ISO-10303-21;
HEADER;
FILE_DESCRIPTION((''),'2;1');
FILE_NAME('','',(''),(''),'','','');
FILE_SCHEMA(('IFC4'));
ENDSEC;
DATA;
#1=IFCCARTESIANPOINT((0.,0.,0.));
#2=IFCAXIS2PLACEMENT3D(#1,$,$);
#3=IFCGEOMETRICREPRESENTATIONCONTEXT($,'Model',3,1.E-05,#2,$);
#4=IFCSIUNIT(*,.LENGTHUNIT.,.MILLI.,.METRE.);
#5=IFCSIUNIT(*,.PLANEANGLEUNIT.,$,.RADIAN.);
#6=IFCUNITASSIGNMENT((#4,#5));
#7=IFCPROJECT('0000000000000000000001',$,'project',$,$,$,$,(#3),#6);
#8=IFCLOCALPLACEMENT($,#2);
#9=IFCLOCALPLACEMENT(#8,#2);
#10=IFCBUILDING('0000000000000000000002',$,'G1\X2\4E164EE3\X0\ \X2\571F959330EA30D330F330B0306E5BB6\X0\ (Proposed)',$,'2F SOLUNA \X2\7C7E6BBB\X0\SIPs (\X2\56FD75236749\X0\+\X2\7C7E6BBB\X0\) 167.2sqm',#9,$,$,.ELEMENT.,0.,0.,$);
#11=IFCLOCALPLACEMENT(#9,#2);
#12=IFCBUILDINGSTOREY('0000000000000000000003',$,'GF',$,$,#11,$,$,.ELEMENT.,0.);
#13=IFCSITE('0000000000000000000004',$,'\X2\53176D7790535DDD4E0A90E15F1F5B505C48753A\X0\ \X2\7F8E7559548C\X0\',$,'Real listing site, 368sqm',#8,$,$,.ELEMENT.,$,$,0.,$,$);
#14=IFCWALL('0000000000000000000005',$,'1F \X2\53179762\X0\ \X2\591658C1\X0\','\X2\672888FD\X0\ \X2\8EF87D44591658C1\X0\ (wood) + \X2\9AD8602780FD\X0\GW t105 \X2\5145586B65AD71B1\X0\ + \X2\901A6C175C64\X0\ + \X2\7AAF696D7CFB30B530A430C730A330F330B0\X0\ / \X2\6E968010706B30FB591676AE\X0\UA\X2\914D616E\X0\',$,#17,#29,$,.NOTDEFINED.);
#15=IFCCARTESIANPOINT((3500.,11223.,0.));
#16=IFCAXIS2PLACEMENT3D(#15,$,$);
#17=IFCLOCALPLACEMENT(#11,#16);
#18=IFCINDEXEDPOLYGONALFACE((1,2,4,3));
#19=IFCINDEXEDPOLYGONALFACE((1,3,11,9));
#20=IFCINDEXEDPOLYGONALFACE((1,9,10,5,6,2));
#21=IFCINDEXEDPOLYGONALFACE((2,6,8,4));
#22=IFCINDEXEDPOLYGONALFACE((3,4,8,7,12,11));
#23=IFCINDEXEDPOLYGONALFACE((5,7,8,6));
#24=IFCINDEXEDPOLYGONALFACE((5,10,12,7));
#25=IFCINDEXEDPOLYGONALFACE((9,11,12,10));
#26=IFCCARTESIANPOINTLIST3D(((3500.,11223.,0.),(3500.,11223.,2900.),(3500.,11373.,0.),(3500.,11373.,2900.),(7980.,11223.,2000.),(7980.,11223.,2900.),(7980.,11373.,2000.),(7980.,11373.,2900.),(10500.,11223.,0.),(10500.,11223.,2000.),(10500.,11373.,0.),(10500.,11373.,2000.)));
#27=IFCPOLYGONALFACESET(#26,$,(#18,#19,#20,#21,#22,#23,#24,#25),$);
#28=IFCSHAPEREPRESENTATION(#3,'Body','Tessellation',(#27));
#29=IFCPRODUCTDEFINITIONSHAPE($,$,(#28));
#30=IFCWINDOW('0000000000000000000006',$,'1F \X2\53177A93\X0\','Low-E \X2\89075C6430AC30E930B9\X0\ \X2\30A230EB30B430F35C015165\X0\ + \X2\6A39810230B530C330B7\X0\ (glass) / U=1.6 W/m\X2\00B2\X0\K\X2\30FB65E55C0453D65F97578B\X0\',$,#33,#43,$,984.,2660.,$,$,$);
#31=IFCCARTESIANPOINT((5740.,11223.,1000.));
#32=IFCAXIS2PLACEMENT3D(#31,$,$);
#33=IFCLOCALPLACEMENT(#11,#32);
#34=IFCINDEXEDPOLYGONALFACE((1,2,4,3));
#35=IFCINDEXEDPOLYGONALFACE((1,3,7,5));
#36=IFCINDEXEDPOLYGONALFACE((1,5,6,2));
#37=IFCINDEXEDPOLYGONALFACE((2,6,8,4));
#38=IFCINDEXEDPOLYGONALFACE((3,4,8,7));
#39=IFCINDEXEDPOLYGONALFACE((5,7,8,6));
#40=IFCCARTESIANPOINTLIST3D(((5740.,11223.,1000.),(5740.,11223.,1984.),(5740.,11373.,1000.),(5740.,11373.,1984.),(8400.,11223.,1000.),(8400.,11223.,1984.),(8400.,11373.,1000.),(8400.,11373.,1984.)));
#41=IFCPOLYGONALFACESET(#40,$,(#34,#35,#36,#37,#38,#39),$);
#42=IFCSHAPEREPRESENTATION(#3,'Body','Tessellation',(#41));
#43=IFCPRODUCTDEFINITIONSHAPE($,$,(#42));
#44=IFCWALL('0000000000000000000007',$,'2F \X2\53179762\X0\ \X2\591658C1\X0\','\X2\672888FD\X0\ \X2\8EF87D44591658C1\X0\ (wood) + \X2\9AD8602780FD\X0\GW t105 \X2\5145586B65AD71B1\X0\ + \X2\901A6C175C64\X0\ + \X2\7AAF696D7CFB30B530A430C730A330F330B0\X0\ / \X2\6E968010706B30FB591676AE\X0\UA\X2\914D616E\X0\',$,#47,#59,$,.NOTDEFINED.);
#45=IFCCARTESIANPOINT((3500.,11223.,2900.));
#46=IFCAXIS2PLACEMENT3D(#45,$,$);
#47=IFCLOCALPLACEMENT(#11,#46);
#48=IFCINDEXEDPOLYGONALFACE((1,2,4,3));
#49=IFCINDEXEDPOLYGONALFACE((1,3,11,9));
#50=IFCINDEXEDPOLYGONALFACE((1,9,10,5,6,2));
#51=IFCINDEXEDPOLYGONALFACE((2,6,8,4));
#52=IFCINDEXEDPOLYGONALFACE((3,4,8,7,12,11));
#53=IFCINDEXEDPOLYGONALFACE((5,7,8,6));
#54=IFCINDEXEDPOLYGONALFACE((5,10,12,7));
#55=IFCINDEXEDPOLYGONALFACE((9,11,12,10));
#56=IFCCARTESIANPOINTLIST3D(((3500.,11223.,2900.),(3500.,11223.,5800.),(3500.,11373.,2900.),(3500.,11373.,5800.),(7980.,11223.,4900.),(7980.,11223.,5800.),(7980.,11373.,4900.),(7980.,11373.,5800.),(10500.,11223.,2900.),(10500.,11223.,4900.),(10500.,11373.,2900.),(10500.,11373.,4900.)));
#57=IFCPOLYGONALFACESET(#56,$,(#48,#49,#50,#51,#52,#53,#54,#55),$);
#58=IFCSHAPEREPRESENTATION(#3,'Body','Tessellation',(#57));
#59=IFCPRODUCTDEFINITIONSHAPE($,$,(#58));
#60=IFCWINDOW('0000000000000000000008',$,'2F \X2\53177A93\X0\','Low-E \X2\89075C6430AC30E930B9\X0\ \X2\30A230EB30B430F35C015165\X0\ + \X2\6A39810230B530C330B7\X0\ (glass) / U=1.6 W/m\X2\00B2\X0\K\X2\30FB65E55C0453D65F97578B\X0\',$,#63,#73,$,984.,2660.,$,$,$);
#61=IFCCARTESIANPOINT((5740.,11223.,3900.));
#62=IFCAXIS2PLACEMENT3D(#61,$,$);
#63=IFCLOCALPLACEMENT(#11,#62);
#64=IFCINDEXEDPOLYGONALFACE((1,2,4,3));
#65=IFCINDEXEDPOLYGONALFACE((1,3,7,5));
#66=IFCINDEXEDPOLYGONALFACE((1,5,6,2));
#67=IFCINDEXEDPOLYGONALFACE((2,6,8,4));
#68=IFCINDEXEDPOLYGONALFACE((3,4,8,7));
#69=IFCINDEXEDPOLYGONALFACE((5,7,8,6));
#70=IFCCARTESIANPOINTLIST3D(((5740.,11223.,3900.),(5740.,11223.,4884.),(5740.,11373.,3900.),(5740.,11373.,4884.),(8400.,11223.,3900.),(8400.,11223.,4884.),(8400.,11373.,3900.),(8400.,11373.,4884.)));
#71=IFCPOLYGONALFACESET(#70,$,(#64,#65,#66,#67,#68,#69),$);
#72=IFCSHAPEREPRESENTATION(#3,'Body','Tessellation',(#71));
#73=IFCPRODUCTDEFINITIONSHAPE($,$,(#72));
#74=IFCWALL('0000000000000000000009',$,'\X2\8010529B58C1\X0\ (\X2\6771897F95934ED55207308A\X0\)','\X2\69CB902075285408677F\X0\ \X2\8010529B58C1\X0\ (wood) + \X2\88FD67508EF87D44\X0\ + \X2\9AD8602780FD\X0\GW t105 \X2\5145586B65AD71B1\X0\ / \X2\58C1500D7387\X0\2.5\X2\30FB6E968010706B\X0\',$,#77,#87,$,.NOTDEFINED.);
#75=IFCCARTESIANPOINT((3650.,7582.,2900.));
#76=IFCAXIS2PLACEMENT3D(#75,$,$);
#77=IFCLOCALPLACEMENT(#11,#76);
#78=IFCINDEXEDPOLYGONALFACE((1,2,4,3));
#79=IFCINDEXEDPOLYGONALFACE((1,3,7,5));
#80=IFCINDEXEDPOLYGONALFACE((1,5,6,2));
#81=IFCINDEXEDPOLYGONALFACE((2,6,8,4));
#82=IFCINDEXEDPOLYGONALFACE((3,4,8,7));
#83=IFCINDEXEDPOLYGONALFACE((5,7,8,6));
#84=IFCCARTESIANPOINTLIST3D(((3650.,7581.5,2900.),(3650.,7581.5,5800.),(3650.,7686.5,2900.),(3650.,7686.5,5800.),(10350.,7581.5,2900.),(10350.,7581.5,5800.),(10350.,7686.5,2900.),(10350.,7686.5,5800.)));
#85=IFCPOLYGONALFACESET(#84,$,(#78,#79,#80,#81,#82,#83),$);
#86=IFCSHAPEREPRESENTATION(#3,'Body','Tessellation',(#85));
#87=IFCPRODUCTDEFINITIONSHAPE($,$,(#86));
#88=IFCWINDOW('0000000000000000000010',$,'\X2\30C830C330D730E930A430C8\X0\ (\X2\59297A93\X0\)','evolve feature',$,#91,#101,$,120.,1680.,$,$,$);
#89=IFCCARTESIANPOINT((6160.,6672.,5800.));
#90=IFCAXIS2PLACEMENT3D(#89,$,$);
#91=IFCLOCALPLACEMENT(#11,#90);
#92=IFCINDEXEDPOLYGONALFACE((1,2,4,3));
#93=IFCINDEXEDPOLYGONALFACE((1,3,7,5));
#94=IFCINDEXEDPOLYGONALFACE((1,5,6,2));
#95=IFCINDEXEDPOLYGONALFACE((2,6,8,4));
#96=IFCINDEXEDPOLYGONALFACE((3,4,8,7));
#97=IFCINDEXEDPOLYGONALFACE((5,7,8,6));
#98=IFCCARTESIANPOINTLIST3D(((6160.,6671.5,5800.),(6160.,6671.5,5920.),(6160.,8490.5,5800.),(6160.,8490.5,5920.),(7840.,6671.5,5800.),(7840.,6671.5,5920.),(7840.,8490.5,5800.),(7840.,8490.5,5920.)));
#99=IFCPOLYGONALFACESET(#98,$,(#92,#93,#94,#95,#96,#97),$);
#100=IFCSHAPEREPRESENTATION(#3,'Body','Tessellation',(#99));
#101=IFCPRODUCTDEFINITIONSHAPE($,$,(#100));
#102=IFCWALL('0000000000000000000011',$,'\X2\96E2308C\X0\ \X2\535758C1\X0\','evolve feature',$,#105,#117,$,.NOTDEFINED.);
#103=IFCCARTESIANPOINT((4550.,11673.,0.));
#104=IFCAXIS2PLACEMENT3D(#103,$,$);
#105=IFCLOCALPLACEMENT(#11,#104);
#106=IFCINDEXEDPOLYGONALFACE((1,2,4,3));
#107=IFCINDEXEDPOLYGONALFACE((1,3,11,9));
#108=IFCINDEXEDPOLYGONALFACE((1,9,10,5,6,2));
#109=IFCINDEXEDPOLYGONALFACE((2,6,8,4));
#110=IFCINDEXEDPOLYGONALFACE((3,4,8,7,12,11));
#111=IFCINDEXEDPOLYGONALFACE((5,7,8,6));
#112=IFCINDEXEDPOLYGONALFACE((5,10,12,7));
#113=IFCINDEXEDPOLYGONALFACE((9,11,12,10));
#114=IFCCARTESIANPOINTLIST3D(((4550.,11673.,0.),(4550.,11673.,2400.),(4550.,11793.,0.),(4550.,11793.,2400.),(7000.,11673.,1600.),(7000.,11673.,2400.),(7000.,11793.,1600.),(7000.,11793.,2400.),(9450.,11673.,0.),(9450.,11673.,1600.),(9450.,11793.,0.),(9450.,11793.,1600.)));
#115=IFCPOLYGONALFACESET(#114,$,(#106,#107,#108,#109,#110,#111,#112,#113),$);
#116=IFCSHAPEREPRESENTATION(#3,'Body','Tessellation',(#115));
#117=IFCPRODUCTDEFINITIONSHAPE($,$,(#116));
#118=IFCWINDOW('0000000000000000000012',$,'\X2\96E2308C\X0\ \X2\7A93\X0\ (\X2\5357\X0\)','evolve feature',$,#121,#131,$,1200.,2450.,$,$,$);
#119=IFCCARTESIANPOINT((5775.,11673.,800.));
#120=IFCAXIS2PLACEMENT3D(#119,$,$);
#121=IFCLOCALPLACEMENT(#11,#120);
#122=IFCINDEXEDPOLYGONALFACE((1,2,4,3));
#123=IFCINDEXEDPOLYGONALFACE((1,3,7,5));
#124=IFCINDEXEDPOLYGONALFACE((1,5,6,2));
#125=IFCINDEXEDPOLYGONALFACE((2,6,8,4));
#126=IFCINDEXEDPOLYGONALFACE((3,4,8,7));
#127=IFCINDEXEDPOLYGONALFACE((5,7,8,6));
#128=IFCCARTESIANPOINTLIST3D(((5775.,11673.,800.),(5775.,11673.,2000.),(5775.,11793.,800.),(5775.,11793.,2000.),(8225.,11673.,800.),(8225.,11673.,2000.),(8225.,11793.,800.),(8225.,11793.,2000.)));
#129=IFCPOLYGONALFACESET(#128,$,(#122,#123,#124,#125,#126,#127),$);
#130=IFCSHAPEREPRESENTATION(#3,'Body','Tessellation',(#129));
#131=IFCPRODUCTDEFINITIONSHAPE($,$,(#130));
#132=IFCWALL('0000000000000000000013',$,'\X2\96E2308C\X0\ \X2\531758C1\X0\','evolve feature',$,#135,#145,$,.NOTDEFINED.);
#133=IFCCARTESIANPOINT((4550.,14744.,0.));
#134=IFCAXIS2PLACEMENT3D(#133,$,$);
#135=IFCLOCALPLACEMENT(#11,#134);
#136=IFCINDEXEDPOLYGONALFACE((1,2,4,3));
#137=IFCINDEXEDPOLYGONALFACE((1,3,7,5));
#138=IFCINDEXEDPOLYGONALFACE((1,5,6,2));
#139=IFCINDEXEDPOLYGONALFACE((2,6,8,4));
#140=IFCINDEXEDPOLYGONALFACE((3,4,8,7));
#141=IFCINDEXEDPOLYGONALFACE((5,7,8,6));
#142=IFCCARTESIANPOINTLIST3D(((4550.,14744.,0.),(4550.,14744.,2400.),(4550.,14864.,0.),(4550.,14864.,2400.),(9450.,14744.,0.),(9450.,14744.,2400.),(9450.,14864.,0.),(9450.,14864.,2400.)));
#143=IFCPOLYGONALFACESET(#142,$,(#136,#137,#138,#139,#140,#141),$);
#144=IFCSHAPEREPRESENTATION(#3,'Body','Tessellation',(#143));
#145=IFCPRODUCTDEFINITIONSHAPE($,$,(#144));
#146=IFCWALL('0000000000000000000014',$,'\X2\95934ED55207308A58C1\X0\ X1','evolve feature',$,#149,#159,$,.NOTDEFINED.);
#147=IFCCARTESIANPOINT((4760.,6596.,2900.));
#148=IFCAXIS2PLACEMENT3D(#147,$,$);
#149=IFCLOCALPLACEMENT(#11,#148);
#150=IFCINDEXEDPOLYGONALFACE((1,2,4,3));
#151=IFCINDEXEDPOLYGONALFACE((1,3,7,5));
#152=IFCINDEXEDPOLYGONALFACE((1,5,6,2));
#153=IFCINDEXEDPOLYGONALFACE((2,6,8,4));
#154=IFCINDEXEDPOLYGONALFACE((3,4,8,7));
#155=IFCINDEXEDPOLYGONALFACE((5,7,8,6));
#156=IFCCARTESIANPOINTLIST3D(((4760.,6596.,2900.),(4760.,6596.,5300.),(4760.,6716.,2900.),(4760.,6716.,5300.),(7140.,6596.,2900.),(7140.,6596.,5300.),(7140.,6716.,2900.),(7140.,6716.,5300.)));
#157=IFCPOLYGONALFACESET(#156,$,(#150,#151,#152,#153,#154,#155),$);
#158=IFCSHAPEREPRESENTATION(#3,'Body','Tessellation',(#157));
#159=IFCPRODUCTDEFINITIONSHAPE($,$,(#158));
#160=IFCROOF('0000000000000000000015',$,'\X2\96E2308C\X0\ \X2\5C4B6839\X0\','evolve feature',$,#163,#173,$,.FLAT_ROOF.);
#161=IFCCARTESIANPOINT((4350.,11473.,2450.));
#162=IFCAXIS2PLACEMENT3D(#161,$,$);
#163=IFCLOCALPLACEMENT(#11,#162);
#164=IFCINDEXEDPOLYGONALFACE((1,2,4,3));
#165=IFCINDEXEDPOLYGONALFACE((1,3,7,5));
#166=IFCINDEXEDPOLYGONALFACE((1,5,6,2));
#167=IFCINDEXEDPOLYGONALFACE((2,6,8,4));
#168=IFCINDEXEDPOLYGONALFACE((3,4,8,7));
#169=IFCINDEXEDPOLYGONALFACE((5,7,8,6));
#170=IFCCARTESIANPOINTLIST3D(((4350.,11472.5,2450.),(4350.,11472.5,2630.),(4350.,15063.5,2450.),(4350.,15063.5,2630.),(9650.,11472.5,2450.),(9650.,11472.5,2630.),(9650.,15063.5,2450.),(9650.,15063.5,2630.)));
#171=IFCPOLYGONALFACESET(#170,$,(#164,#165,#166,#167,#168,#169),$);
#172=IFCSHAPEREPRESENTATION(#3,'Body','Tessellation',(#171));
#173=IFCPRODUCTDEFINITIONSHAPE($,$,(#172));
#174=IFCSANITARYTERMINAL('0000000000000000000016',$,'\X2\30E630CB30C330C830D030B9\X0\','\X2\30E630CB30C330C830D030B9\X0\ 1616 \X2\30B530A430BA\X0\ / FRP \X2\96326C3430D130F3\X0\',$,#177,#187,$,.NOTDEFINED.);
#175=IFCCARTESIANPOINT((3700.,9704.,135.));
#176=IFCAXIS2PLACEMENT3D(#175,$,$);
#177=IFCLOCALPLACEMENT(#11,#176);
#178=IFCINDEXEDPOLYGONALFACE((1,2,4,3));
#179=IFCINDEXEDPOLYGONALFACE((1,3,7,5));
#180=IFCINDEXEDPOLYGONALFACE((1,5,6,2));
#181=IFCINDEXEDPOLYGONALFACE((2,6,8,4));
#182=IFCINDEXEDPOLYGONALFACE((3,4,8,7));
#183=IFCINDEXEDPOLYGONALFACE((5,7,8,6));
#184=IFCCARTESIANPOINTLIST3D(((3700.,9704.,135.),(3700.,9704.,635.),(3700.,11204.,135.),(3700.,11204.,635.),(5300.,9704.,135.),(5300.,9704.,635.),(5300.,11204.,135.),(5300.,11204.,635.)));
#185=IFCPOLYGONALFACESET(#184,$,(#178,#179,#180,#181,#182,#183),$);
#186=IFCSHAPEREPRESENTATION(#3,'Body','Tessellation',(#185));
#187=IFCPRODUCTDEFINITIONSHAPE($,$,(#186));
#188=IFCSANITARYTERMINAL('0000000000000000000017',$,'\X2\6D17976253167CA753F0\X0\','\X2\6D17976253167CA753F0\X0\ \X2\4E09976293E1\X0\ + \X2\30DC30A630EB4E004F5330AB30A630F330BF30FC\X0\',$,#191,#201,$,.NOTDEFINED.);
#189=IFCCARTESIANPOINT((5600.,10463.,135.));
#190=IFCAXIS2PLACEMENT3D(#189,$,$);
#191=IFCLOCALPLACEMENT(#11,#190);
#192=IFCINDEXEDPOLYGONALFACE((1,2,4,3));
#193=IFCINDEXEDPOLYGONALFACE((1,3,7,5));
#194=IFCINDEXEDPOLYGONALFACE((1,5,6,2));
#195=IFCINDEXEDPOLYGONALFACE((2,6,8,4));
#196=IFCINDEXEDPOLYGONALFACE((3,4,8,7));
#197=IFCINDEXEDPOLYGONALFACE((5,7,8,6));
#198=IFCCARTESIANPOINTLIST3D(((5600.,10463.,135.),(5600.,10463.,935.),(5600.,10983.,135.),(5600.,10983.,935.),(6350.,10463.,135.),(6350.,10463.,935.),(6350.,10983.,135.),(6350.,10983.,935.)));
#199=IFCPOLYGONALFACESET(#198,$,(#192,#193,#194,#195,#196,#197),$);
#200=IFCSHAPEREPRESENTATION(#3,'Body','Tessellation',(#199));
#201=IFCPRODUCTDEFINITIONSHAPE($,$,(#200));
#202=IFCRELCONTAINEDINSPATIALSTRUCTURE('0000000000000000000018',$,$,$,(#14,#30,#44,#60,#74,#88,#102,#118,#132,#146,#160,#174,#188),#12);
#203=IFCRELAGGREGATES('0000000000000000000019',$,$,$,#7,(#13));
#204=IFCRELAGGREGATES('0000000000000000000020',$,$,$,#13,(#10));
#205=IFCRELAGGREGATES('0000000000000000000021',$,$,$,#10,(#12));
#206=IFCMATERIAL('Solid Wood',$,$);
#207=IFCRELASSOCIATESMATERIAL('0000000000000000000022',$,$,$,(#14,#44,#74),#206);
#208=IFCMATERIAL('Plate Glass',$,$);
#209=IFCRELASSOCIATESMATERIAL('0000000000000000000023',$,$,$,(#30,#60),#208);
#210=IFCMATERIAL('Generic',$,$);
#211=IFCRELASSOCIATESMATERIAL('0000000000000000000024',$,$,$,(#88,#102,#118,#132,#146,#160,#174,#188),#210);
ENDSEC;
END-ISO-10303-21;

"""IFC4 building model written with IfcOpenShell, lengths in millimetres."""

from ifc_helpers import new_model, si_unit, frame, frame_2d, origin, place, context, project, spatial, rectangle, extrude, material, element, fill, save


model = new_model("IFC4")

# Units and contexts
model_context = context("Model", 3, precision=1e-05, world=origin())
ifc_project = project(units=[si_unit("LENGTHUNIT", "METRE", prefix="MILLI"), si_unit("PLANEANGLEUNIT", "RADIAN")], contexts=[model_context])

# Site, building, storey
site_placement = place(None, origin())
site = spatial("IfcSite", under=ifc_project, at=site_placement, Name="北海道川上郡弟子屈町 美留和", ObjectType="Real listing site, 368sqm", CompositionType="ELEMENT", RefElevation=0.0)
building_placement = place(site_placement, origin())
building = spatial("IfcBuilding", under=site, at=building_placement, Name="G1世代 土間リビングの家 (Proposed)", ObjectType="2F SOLUNA 籾殻SIPs (国産杉+籾殻) 167.2sqm", CompositionType="ELEMENT", ElevationOfRefHeight=0.0, ElevationOfTerrain=0.0)
storey_placement = place(building_placement, origin())
storey = spatial("IfcBuildingStorey", under=building, at=storey_placement, Name="GF", CompositionType="ELEMENT", Elevation=0.0)

# Shared definitions
ifc_material_1 = material(Name="Generic")

# Wall, opening, window
ifc_material_2 = material(Name="Solid Wood")
wall_1_placement = place(storey_placement, frame((3500.0, 11223.0, 0.0)))
wall_1 = element("IfcWall", 1, at=wall_1_placement, inside=storey, material=ifc_material_2, Name="1F 北面 外壁", Description="木製 軸組外壁 (wood) + 高性能GW t105 充填断熱 + 通気層 + 窯業系サイディング / 準耐火・外皮UA配慮", PredefinedType="NOTDEFINED", context=model_context, shape_type="SweptSolid", body=[
    extrude(rectangle(XDim=7000.0, YDim=150.0, at=frame_2d((3500.0, 75.0))), frame((3500.0, 11223.0, 0.0)), (0.0, 0.0, 1.0), 2900.0),
])
opening_1_placement = place(storey_placement, frame((5740.0, 11223.0, 1000.0)))
opening_1 = element("IfcOpeningElement", 2, at=opening_1_placement, cuts=wall_1, PredefinedType="NOTDEFINED", context=model_context, shape_type="SweptSolid", body=[
    extrude(rectangle(XDim=2660.0, YDim=150.0, at=frame_2d((1330.0, 75.0))), frame((5740.0, 11223.0, 1000.0)), (0.0, 0.0, 1.0), 984.0),
])
ifc_material_3 = material(Name="Plate Glass")
window_1_placement = place(storey_placement, frame((5740.0, 11223.0, 1000.0)))
window_1 = element("IfcWindow", 3, at=window_1_placement, inside=storey, material=ifc_material_3, Name="1F 北窓", Description="Low-E 複層ガラス アルゴン封入 + 樹脂サッシ (glass) / U=1.6 W/m²K・日射取得型", OverallHeight=984.0, OverallWidth=2660.0, context=model_context, shape_type="SweptSolid", body=[
    extrude(rectangle(XDim=2660.0, YDim=150.0, at=frame_2d((1330.0, 75.0))), frame((5740.0, 11223.0, 1000.0)), (0.0, 0.0, 1.0), 984.0),
])
fill(opening_1, window_1)

# Wall, opening, window
wall_2_placement = place(storey_placement, frame((3500.0, 11223.0, 2900.0)))
wall_2 = element("IfcWall", 4, at=wall_2_placement, inside=storey, material=ifc_material_2, Name="2F 北面 外壁", Description="木製 軸組外壁 (wood) + 高性能GW t105 充填断熱 + 通気層 + 窯業系サイディング / 準耐火・外皮UA配慮", PredefinedType="NOTDEFINED", context=model_context, shape_type="SweptSolid", body=[
    extrude(rectangle(XDim=7000.0, YDim=150.0, at=frame_2d((3500.0, 75.0))), frame((3500.0, 11223.0, 2900.0)), (0.0, 0.0, 1.0), 2900.0),
])
opening_2_placement = place(storey_placement, frame((5740.0, 11223.0, 3900.0)))
opening_2 = element("IfcOpeningElement", 5, at=opening_2_placement, cuts=wall_2, PredefinedType="NOTDEFINED", context=model_context, shape_type="SweptSolid", body=[
    extrude(rectangle(XDim=2660.0, YDim=150.0, at=frame_2d((1330.0, 75.0))), frame((5740.0, 11223.0, 3900.0)), (0.0, 0.0, 1.0), 984.0),
])
window_2_placement = place(storey_placement, frame((5740.0, 11223.0, 3900.0)))
window_2 = element("IfcWindow", 6, at=window_2_placement, inside=storey, material=ifc_material_3, Name="2F 北窓", Description="Low-E 複層ガラス アルゴン封入 + 樹脂サッシ (glass) / U=1.6 W/m²K・日射取得型", OverallHeight=984.0, OverallWidth=2660.0, context=model_context, shape_type="SweptSolid", body=[
    extrude(rectangle(XDim=2660.0, YDim=150.0, at=frame_2d((1330.0, 75.0))), frame((5740.0, 11223.0, 3900.0)), (0.0, 0.0, 1.0), 984.0),
])
fill(opening_2, window_2)

# Wall
wall_3_placement = place(storey_placement, frame((3650.0, 7582.0, 2900.0)))
element("IfcWall", 7, at=wall_3_placement, inside=storey, material=ifc_material_2, Name="耐力壁 (東西間仕切り)", Description="構造用合板 耐力壁 (wood) + 製材軸組 + 高性能GW t105 充填断熱 / 壁倍率2.5・準耐火", PredefinedType="NOTDEFINED", context=model_context, shape_type="SweptSolid", body=[
    extrude(rectangle(XDim=6700.0, YDim=105.0, at=frame_2d((3350.0, 52.0))), frame((3650.0, 7582.0, 2900.0)), (0.0, 0.0, 1.0), 2900.0),
])

# Window
window_3_placement = place(storey_placement, frame((6160.0, 6672.0, 5800.0)))
element("IfcWindow", 8, at=window_3_placement, inside=storey, material=ifc_material_1, Name="トップライト (天窓)", Description="evolve feature", OverallHeight=120.0, OverallWidth=1680.0, context=model_context, shape_type="SweptSolid", body=[
    extrude(rectangle(XDim=1680.0, YDim=1819.0, at=frame_2d((840.0, 909.0))), frame((6160.0, 6672.0, 5800.0)), (0.0, 0.0, 1.0), 120.0),
])

# Wall, opening, window
wall_4_placement = place(storey_placement, frame((4550.0, 11673.0, 0.0)))
wall_4 = element("IfcWall", 9, at=wall_4_placement, inside=storey, material=ifc_material_1, Name="離れ 南壁", Description="evolve feature", PredefinedType="NOTDEFINED", context=model_context, shape_type="SweptSolid", body=[
    extrude(rectangle(XDim=4900.0, YDim=120.0, at=frame_2d((2450.0, 60.0))), frame((4550.0, 11673.0, 0.0)), (0.0, 0.0, 1.0), 2400.0),
])
opening_3_placement = place(storey_placement, frame((5775.0, 11673.0, 800.0)))
opening_3 = element("IfcOpeningElement", 10, at=opening_3_placement, cuts=wall_4, PredefinedType="NOTDEFINED", context=model_context, shape_type="SweptSolid", body=[
    extrude(rectangle(XDim=2450.0, YDim=120.0, at=frame_2d((1225.0, 60.0))), frame((5775.0, 11673.0, 800.0)), (0.0, 0.0, 1.0), 1200.0),
])
window_4_placement = place(storey_placement, frame((5775.0, 11673.0, 800.0)))
window_4 = element("IfcWindow", 11, at=window_4_placement, inside=storey, material=ifc_material_1, Name="離れ 窓 (南)", Description="evolve feature", OverallHeight=1200.0, OverallWidth=2450.0, context=model_context, shape_type="SweptSolid", body=[
    extrude(rectangle(XDim=2450.0, YDim=120.0, at=frame_2d((1225.0, 60.0))), frame((5775.0, 11673.0, 800.0)), (0.0, 0.0, 1.0), 1200.0),
])
fill(opening_3, window_4)

# Walls
wall_5_placement = place(storey_placement, frame((4550.0, 14744.0, 0.0)))
element("IfcWall", 12, at=wall_5_placement, inside=storey, material=ifc_material_1, Name="離れ 北壁", Description="evolve feature", PredefinedType="NOTDEFINED", context=model_context, shape_type="SweptSolid", body=[
    extrude(rectangle(XDim=4900.0, YDim=120.0, at=frame_2d((2450.0, 60.0))), frame((4550.0, 14744.0, 0.0)), (0.0, 0.0, 1.0), 2400.0),
])
wall_6_placement = place(storey_placement, frame((4760.0, 6596.0, 2900.0)))
element("IfcWall", 13, at=wall_6_placement, inside=storey, material=ifc_material_1, Name="間仕切り壁 X1", Description="evolve feature", PredefinedType="NOTDEFINED", context=model_context, shape_type="SweptSolid", body=[
    extrude(rectangle(XDim=2380.0, YDim=120.0, at=frame_2d((1190.0, 60.0))), frame((4760.0, 6596.0, 2900.0)), (0.0, 0.0, 1.0), 2400.0),
])

# Roof
roof_placement = place(storey_placement, frame((4350.0, 11473.0, 2450.0)))
element("IfcRoof", 14, at=roof_placement, inside=storey, material=ifc_material_1, Name="離れ 屋根", Description="evolve feature", PredefinedType="FLAT_ROOF", context=model_context, shape_type="SweptSolid", body=[
    extrude(rectangle(XDim=5300.0, YDim=3591.0, at=frame_2d((2650.0, 1795.0))), frame((4350.0, 11473.0, 2450.0)), (0.0, 0.0, 1.0), 180.0),
])

# Sanitary terminals
sanitary_terminal_1_placement = place(storey_placement, frame((3700.0, 9704.0, 135.0)))
element("IfcSanitaryTerminal", 15, at=sanitary_terminal_1_placement, inside=storey, material=ifc_material_1, Name="ユニットバス", Description="ユニットバス 1616 サイズ / FRP 防水パン", PredefinedType="NOTDEFINED", context=model_context, shape_type="SweptSolid", body=[
    extrude(rectangle(XDim=1600.0, YDim=1500.0, at=frame_2d((800.0, 750.0))), frame((3700.0, 9704.0, 135.0)), (0.0, 0.0, 1.0), 500.0),
])
sanitary_terminal_2_placement = place(storey_placement, frame((5600.0, 10463.0, 135.0)))
element("IfcSanitaryTerminal", 16, at=sanitary_terminal_2_placement, inside=storey, material=ifc_material_1, Name="洗面化粧台", Description="洗面化粧台 三面鏡 + ボウル一体カウンター", PredefinedType="NOTDEFINED", context=model_context, shape_type="SweptSolid", body=[
    extrude(rectangle(XDim=750.0, YDim=520.0, at=frame_2d((375.0, 260.0))), frame((5600.0, 10463.0, 135.0)), (0.0, 0.0, 1.0), 800.0),
])

save(model, "model.ifc")
